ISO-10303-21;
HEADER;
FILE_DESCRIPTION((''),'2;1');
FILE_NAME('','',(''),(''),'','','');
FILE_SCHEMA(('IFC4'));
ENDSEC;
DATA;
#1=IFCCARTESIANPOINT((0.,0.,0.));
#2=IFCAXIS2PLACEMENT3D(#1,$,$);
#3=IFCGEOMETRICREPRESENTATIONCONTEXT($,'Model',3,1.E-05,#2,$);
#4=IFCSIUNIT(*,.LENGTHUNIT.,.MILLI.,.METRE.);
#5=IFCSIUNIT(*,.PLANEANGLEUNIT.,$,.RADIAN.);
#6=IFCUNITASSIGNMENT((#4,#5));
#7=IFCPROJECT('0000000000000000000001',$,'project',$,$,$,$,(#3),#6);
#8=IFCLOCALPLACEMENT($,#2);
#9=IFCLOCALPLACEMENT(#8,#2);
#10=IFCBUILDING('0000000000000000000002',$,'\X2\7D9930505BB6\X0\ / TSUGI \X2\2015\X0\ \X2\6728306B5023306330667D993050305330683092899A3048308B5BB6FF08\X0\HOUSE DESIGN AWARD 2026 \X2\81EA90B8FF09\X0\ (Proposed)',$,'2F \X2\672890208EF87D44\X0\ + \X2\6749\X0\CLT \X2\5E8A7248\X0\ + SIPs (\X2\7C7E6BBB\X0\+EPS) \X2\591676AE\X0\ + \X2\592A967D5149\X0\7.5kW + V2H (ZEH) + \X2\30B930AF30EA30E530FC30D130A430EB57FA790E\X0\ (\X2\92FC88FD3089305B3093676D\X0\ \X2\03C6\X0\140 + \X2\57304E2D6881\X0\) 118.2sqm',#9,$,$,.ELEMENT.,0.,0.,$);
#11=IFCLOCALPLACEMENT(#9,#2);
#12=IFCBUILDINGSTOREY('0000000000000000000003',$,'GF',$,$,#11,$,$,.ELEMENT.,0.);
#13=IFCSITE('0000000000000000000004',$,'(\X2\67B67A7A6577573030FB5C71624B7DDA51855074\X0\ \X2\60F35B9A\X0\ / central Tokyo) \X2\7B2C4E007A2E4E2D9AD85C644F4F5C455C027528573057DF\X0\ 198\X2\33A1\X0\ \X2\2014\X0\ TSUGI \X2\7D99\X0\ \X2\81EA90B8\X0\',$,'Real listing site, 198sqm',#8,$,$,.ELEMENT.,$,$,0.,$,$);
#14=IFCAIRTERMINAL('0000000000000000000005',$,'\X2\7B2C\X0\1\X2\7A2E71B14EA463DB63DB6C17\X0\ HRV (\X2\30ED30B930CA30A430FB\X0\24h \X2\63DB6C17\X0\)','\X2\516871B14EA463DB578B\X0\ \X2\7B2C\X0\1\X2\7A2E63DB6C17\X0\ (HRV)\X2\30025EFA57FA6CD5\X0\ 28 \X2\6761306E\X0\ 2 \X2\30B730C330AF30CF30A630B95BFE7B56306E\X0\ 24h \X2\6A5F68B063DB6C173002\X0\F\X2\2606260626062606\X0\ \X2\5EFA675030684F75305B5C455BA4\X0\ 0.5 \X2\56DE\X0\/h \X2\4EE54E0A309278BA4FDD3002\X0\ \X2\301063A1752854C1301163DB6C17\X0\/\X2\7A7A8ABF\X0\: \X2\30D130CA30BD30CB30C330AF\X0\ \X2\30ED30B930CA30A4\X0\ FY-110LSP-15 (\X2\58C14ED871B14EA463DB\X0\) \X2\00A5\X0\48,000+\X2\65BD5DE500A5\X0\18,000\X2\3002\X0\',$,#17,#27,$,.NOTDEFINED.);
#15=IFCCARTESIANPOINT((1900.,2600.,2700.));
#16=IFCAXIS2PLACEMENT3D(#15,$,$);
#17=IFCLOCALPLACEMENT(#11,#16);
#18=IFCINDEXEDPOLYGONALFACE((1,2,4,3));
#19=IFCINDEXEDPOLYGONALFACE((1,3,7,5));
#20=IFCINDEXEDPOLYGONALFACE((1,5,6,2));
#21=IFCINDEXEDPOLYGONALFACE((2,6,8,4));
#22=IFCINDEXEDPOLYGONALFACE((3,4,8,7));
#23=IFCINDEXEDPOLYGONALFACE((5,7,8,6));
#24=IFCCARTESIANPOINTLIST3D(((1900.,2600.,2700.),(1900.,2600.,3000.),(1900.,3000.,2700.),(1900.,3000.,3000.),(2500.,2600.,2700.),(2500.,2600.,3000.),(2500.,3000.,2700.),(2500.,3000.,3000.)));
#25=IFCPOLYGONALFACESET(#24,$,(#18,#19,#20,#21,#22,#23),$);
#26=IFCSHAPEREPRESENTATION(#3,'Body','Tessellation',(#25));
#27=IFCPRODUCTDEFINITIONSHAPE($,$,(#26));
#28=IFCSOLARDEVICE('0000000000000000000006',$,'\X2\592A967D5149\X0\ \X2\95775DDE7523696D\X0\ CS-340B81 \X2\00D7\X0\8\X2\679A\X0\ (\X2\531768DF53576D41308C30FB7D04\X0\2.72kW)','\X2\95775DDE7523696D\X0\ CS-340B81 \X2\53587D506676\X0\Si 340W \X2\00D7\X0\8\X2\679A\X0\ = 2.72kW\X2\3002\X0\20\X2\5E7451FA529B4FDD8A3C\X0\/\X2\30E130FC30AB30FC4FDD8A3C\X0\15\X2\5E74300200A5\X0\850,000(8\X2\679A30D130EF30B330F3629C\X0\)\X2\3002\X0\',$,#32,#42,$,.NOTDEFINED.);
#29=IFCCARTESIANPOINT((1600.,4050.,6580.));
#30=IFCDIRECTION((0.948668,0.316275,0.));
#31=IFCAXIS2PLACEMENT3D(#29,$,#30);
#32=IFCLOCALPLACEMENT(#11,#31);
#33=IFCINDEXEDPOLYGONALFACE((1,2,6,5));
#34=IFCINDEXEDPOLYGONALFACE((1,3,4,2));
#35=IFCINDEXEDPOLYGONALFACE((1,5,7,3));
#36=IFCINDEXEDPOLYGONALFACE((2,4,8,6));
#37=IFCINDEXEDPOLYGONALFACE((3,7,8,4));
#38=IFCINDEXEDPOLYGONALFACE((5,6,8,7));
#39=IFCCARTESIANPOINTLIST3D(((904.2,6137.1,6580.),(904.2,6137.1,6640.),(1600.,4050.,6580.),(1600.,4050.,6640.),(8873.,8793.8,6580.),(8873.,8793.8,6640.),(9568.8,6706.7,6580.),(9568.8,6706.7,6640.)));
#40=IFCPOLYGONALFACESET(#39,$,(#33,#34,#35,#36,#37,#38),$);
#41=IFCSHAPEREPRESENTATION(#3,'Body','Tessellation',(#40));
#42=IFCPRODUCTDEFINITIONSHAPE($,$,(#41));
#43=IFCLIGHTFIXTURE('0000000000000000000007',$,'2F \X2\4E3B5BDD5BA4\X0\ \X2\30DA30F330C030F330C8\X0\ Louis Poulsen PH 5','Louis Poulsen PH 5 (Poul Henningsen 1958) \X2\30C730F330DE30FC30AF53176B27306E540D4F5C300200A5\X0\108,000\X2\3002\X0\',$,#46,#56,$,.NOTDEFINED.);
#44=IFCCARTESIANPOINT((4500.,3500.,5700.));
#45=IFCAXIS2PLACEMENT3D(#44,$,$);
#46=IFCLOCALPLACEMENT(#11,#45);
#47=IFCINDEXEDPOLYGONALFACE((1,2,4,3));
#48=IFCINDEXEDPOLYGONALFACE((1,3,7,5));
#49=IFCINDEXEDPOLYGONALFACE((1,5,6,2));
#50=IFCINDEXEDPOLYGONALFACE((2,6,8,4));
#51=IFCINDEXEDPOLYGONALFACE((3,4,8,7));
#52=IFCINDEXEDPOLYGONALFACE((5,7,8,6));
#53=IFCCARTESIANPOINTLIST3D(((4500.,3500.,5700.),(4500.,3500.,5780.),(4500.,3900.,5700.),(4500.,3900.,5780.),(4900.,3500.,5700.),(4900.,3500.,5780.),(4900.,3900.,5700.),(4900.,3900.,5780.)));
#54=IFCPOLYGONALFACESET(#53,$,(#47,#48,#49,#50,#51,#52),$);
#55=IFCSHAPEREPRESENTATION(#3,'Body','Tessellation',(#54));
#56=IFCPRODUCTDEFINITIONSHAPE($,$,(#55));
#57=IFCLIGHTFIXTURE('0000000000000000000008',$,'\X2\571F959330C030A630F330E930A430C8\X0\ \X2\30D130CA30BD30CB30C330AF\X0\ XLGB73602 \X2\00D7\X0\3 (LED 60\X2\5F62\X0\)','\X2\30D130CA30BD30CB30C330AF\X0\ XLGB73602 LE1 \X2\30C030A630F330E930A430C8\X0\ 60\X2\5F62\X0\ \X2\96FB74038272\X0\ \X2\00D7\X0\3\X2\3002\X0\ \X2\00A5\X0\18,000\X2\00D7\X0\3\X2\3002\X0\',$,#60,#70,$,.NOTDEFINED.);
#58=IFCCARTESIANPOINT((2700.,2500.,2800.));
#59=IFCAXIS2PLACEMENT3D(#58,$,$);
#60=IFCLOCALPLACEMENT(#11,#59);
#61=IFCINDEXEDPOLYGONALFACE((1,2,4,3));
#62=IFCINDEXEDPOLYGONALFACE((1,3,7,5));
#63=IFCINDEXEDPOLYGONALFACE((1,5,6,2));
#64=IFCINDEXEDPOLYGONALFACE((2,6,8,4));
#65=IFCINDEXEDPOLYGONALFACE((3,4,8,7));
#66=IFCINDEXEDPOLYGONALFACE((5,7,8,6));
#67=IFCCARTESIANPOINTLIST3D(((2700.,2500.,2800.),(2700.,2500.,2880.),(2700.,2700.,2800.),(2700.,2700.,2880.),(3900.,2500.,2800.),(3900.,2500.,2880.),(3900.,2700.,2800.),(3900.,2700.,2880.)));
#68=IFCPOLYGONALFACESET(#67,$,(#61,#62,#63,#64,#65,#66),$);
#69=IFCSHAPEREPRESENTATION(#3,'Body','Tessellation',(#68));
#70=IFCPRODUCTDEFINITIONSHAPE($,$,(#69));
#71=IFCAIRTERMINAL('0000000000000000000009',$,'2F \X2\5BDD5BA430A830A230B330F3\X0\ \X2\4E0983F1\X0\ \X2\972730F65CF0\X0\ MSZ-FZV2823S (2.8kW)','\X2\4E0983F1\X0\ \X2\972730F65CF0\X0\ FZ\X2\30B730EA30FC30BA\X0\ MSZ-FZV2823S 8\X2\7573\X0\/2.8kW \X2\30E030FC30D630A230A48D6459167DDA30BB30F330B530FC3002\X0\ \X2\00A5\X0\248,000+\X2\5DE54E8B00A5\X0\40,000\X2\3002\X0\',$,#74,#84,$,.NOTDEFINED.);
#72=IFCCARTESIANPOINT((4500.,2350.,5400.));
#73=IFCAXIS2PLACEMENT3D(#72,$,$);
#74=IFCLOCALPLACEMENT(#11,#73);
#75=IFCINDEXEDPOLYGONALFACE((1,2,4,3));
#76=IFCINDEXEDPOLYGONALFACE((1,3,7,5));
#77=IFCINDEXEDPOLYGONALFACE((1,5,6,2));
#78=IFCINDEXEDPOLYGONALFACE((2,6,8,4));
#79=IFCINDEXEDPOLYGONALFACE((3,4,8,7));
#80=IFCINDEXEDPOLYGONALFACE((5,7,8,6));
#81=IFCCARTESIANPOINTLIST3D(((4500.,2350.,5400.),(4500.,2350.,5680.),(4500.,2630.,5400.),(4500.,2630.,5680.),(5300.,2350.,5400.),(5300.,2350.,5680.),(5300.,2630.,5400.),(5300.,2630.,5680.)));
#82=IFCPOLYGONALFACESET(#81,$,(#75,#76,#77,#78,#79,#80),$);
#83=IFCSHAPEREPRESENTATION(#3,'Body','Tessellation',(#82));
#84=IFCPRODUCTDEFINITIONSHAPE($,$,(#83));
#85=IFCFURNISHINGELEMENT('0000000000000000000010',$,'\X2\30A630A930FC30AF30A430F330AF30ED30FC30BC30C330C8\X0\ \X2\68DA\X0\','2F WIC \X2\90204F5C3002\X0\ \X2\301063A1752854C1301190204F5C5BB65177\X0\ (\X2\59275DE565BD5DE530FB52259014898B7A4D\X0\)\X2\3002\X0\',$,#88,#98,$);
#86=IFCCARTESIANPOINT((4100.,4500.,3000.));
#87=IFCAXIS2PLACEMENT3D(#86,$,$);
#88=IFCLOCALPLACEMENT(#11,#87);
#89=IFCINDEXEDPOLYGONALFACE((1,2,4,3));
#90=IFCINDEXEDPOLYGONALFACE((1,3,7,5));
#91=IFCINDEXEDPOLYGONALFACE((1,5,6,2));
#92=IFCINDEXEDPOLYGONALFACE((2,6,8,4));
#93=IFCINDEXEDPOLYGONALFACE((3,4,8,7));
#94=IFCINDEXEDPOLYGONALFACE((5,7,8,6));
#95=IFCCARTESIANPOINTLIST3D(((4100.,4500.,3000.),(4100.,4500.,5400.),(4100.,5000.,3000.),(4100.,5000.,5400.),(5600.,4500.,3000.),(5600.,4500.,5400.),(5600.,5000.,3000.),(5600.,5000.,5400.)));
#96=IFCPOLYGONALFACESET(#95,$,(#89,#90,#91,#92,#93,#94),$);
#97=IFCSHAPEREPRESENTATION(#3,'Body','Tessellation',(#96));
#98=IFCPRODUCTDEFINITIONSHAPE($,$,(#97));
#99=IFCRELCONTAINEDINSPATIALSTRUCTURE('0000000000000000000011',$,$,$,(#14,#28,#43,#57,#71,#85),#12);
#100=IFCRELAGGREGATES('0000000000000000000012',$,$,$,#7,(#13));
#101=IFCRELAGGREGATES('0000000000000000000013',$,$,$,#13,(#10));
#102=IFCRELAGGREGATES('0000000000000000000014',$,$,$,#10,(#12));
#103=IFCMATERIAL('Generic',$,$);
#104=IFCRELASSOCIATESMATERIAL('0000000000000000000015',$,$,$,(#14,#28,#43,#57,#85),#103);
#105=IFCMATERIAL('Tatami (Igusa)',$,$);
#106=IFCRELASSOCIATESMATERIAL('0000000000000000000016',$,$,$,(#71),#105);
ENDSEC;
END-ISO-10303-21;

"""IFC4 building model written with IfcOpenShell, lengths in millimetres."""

from ifc_helpers import new_model, si_unit, frame, frame_2d, origin, place, context, project, spatial, rectangle, extrude, material, element, save


model = new_model("IFC4")

# Units and contexts
model_context = context("Model", 3, precision=1e-05, world=origin())
ifc_project = project(units=[si_unit("LENGTHUNIT", "METRE", prefix="MILLI"), si_unit("PLANEANGLEUNIT", "RADIAN")], contexts=[model_context])

# Site, building, storey
site_placement = place(None, origin())
site = spatial("IfcSite", under=ifc_project, at=site_placement, Name="(架空敷地・山手線内側 想定 / central Tokyo) 第一種中高層住居専用地域 198㎡ — TSUGI 継 自邸", ObjectType="Real listing site, 198sqm", CompositionType="ELEMENT", RefElevation=0.0)
building_placement = place(site_placement, origin())
building = spatial("IfcBuilding", under=site, at=building_placement, Name="継ぐ家 / TSUGI ― 木に倣って継ぐことを覚える家（HOUSE DESIGN AWARD 2026 自邸） (Proposed)", ObjectType="2F 木造軸組 + 杉CLT 床版 + SIPs (籾殻+EPS) 外皮 + 太陽光7.5kW + V2H (ZEH) + スクリューパイル基礎 (鋼製らせん杭 φ140 + 地中梁) 118.2sqm", CompositionType="ELEMENT", ElevationOfRefHeight=0.0, ElevationOfTerrain=0.0)
storey_placement = place(building_placement, origin())
storey = spatial("IfcBuildingStorey", under=building, at=storey_placement, Name="GF", CompositionType="ELEMENT", Elevation=0.0)

# Shared definitions
ifc_material_1 = material(Name="Generic")

# Air terminal
air_terminal_1_placement = place(storey_placement, frame((1900.0, 2600.0, 2700.0)))
element("IfcAirTerminal", 1, at=air_terminal_1_placement, inside=storey, material=ifc_material_1, Name="第1種熱交換換気 HRV (ロスナイ・24h 換気)", Description="全熱交換型 第1種換気 (HRV)。建基法 28 条の 2 シックハウス対策の 24h 機械換気。F☆☆☆☆ 建材と併せ居室 0.5 回/h 以上を確保。 【採用品】換気/空調: パナソニック ロスナイ FY-110LSP-15 (壁付熱交換) ¥48,000+施工¥18,000。", PredefinedType="NOTDEFINED", context=model_context, shape_type="SweptSolid", body=[
    extrude(rectangle(XDim=600.0, YDim=400.0, at=frame_2d((300.0, 200.0))), frame((1900.0, 2600.0, 2700.0)), (0.0, 0.0, 1.0), 300.0),
])

# Solar device
solar_device_placement = place(storey_placement, frame((1600.0, 4050.0, 6580.0), x_axis=(0.948668, 0.316275, 0.0)))
element("IfcSolarDevice", 2, at=solar_device_placement, inside=storey, material=ifc_material_1, Name="太陽光 長州産業 CS-340B81 ×8枚 (北棟南流れ・約2.72kW)", Description="長州産業 CS-340B81 単結晶Si 340W ×8枚 = 2.72kW。20年出力保証/メーカー保証15年。¥850,000(8枚パワコン抜)。", PredefinedType="NOTDEFINED", context=model_context, shape_type="SweptSolid", body=[
    extrude(rectangle(XDim=8400.0, YDim=2200.0, at=frame_2d((4200.0, 1100.0))), frame((1600.0, 4050.0, 6580.0), x_axis=(0.948668, 0.316275, 0.0)), (0.0, 0.0, 1.0), 60.0),
])

# Light fixtures
light_fixture_1_placement = place(storey_placement, frame((4500.0, 3500.0, 5700.0)))
element("IfcLightFixture", 3, at=light_fixture_1_placement, inside=storey, material=ifc_material_1, Name="2F 主寝室 ペンダント Louis Poulsen PH 5", Description="Louis Poulsen PH 5 (Poul Henningsen 1958) デンマーク北欧の名作。¥108,000。", PredefinedType="NOTDEFINED", context=model_context, shape_type="SweptSolid", body=[
    extrude(rectangle(XDim=400.0, YDim=400.0, at=frame_2d((200.0, 200.0))), frame((4500.0, 3500.0, 5700.0)), (0.0, 0.0, 1.0), 80.0),
])
light_fixture_2_placement = place(storey_placement, frame((2700.0, 2500.0, 2800.0)))
element("IfcLightFixture", 4, at=light_fixture_2_placement, inside=storey, material=ifc_material_1, Name="土間ダウンライト パナソニック XLGB73602 ×3 (LED 60形)", Description="パナソニック XLGB73602 LE1 ダウンライト 60形 電球色 ×3。 ¥18,000×3。", PredefinedType="NOTDEFINED", context=model_context, shape_type="SweptSolid", body=[
    extrude(rectangle(XDim=1200.0, YDim=200.0, at=frame_2d((600.0, 100.0))), frame((2700.0, 2500.0, 2800.0)), (0.0, 0.0, 1.0), 80.0),
])

# Air terminal
ifc_material_2 = material(Name="Tatami (Igusa)")
air_terminal_2_placement = place(storey_placement, frame((4500.0, 2350.0, 5400.0)))
element("IfcAirTerminal", 5, at=air_terminal_2_placement, inside=storey, material=ifc_material_2, Name="2F 寝室エアコン 三菱 霧ヶ峰 MSZ-FZV2823S (2.8kW)", Description="三菱 霧ヶ峰 FZシリーズ MSZ-FZV2823S 8畳/2.8kW ムーブアイ赤外線センサー。 ¥248,000+工事¥40,000。", PredefinedType="NOTDEFINED", context=model_context, shape_type="SweptSolid", body=[
    extrude(rectangle(XDim=800.0, YDim=280.0, at=frame_2d((400.0, 140.0))), frame((4500.0, 2350.0, 5400.0)), (0.0, 0.0, 1.0), 280.0),
])

# Furnishing element
furnishing_placement = place(storey_placement, frame((4100.0, 4500.0, 3000.0)))
element("IfcFurnishingElement", 6, at=furnishing_placement, inside=storey, material=ifc_material_1, Name="ウォークインクローゼット 棚", Description="2F WIC 造作。 【採用品】造作家具 (大工施工・別途見積)。", context=model_context, shape_type="SweptSolid", body=[
    extrude(rectangle(XDim=1500.0, YDim=500.0, at=frame_2d((750.0, 250.0))), frame((4100.0, 4500.0, 3000.0)), (0.0, 0.0, 1.0), 2400.0),
])

save(model, "model.ifc")
